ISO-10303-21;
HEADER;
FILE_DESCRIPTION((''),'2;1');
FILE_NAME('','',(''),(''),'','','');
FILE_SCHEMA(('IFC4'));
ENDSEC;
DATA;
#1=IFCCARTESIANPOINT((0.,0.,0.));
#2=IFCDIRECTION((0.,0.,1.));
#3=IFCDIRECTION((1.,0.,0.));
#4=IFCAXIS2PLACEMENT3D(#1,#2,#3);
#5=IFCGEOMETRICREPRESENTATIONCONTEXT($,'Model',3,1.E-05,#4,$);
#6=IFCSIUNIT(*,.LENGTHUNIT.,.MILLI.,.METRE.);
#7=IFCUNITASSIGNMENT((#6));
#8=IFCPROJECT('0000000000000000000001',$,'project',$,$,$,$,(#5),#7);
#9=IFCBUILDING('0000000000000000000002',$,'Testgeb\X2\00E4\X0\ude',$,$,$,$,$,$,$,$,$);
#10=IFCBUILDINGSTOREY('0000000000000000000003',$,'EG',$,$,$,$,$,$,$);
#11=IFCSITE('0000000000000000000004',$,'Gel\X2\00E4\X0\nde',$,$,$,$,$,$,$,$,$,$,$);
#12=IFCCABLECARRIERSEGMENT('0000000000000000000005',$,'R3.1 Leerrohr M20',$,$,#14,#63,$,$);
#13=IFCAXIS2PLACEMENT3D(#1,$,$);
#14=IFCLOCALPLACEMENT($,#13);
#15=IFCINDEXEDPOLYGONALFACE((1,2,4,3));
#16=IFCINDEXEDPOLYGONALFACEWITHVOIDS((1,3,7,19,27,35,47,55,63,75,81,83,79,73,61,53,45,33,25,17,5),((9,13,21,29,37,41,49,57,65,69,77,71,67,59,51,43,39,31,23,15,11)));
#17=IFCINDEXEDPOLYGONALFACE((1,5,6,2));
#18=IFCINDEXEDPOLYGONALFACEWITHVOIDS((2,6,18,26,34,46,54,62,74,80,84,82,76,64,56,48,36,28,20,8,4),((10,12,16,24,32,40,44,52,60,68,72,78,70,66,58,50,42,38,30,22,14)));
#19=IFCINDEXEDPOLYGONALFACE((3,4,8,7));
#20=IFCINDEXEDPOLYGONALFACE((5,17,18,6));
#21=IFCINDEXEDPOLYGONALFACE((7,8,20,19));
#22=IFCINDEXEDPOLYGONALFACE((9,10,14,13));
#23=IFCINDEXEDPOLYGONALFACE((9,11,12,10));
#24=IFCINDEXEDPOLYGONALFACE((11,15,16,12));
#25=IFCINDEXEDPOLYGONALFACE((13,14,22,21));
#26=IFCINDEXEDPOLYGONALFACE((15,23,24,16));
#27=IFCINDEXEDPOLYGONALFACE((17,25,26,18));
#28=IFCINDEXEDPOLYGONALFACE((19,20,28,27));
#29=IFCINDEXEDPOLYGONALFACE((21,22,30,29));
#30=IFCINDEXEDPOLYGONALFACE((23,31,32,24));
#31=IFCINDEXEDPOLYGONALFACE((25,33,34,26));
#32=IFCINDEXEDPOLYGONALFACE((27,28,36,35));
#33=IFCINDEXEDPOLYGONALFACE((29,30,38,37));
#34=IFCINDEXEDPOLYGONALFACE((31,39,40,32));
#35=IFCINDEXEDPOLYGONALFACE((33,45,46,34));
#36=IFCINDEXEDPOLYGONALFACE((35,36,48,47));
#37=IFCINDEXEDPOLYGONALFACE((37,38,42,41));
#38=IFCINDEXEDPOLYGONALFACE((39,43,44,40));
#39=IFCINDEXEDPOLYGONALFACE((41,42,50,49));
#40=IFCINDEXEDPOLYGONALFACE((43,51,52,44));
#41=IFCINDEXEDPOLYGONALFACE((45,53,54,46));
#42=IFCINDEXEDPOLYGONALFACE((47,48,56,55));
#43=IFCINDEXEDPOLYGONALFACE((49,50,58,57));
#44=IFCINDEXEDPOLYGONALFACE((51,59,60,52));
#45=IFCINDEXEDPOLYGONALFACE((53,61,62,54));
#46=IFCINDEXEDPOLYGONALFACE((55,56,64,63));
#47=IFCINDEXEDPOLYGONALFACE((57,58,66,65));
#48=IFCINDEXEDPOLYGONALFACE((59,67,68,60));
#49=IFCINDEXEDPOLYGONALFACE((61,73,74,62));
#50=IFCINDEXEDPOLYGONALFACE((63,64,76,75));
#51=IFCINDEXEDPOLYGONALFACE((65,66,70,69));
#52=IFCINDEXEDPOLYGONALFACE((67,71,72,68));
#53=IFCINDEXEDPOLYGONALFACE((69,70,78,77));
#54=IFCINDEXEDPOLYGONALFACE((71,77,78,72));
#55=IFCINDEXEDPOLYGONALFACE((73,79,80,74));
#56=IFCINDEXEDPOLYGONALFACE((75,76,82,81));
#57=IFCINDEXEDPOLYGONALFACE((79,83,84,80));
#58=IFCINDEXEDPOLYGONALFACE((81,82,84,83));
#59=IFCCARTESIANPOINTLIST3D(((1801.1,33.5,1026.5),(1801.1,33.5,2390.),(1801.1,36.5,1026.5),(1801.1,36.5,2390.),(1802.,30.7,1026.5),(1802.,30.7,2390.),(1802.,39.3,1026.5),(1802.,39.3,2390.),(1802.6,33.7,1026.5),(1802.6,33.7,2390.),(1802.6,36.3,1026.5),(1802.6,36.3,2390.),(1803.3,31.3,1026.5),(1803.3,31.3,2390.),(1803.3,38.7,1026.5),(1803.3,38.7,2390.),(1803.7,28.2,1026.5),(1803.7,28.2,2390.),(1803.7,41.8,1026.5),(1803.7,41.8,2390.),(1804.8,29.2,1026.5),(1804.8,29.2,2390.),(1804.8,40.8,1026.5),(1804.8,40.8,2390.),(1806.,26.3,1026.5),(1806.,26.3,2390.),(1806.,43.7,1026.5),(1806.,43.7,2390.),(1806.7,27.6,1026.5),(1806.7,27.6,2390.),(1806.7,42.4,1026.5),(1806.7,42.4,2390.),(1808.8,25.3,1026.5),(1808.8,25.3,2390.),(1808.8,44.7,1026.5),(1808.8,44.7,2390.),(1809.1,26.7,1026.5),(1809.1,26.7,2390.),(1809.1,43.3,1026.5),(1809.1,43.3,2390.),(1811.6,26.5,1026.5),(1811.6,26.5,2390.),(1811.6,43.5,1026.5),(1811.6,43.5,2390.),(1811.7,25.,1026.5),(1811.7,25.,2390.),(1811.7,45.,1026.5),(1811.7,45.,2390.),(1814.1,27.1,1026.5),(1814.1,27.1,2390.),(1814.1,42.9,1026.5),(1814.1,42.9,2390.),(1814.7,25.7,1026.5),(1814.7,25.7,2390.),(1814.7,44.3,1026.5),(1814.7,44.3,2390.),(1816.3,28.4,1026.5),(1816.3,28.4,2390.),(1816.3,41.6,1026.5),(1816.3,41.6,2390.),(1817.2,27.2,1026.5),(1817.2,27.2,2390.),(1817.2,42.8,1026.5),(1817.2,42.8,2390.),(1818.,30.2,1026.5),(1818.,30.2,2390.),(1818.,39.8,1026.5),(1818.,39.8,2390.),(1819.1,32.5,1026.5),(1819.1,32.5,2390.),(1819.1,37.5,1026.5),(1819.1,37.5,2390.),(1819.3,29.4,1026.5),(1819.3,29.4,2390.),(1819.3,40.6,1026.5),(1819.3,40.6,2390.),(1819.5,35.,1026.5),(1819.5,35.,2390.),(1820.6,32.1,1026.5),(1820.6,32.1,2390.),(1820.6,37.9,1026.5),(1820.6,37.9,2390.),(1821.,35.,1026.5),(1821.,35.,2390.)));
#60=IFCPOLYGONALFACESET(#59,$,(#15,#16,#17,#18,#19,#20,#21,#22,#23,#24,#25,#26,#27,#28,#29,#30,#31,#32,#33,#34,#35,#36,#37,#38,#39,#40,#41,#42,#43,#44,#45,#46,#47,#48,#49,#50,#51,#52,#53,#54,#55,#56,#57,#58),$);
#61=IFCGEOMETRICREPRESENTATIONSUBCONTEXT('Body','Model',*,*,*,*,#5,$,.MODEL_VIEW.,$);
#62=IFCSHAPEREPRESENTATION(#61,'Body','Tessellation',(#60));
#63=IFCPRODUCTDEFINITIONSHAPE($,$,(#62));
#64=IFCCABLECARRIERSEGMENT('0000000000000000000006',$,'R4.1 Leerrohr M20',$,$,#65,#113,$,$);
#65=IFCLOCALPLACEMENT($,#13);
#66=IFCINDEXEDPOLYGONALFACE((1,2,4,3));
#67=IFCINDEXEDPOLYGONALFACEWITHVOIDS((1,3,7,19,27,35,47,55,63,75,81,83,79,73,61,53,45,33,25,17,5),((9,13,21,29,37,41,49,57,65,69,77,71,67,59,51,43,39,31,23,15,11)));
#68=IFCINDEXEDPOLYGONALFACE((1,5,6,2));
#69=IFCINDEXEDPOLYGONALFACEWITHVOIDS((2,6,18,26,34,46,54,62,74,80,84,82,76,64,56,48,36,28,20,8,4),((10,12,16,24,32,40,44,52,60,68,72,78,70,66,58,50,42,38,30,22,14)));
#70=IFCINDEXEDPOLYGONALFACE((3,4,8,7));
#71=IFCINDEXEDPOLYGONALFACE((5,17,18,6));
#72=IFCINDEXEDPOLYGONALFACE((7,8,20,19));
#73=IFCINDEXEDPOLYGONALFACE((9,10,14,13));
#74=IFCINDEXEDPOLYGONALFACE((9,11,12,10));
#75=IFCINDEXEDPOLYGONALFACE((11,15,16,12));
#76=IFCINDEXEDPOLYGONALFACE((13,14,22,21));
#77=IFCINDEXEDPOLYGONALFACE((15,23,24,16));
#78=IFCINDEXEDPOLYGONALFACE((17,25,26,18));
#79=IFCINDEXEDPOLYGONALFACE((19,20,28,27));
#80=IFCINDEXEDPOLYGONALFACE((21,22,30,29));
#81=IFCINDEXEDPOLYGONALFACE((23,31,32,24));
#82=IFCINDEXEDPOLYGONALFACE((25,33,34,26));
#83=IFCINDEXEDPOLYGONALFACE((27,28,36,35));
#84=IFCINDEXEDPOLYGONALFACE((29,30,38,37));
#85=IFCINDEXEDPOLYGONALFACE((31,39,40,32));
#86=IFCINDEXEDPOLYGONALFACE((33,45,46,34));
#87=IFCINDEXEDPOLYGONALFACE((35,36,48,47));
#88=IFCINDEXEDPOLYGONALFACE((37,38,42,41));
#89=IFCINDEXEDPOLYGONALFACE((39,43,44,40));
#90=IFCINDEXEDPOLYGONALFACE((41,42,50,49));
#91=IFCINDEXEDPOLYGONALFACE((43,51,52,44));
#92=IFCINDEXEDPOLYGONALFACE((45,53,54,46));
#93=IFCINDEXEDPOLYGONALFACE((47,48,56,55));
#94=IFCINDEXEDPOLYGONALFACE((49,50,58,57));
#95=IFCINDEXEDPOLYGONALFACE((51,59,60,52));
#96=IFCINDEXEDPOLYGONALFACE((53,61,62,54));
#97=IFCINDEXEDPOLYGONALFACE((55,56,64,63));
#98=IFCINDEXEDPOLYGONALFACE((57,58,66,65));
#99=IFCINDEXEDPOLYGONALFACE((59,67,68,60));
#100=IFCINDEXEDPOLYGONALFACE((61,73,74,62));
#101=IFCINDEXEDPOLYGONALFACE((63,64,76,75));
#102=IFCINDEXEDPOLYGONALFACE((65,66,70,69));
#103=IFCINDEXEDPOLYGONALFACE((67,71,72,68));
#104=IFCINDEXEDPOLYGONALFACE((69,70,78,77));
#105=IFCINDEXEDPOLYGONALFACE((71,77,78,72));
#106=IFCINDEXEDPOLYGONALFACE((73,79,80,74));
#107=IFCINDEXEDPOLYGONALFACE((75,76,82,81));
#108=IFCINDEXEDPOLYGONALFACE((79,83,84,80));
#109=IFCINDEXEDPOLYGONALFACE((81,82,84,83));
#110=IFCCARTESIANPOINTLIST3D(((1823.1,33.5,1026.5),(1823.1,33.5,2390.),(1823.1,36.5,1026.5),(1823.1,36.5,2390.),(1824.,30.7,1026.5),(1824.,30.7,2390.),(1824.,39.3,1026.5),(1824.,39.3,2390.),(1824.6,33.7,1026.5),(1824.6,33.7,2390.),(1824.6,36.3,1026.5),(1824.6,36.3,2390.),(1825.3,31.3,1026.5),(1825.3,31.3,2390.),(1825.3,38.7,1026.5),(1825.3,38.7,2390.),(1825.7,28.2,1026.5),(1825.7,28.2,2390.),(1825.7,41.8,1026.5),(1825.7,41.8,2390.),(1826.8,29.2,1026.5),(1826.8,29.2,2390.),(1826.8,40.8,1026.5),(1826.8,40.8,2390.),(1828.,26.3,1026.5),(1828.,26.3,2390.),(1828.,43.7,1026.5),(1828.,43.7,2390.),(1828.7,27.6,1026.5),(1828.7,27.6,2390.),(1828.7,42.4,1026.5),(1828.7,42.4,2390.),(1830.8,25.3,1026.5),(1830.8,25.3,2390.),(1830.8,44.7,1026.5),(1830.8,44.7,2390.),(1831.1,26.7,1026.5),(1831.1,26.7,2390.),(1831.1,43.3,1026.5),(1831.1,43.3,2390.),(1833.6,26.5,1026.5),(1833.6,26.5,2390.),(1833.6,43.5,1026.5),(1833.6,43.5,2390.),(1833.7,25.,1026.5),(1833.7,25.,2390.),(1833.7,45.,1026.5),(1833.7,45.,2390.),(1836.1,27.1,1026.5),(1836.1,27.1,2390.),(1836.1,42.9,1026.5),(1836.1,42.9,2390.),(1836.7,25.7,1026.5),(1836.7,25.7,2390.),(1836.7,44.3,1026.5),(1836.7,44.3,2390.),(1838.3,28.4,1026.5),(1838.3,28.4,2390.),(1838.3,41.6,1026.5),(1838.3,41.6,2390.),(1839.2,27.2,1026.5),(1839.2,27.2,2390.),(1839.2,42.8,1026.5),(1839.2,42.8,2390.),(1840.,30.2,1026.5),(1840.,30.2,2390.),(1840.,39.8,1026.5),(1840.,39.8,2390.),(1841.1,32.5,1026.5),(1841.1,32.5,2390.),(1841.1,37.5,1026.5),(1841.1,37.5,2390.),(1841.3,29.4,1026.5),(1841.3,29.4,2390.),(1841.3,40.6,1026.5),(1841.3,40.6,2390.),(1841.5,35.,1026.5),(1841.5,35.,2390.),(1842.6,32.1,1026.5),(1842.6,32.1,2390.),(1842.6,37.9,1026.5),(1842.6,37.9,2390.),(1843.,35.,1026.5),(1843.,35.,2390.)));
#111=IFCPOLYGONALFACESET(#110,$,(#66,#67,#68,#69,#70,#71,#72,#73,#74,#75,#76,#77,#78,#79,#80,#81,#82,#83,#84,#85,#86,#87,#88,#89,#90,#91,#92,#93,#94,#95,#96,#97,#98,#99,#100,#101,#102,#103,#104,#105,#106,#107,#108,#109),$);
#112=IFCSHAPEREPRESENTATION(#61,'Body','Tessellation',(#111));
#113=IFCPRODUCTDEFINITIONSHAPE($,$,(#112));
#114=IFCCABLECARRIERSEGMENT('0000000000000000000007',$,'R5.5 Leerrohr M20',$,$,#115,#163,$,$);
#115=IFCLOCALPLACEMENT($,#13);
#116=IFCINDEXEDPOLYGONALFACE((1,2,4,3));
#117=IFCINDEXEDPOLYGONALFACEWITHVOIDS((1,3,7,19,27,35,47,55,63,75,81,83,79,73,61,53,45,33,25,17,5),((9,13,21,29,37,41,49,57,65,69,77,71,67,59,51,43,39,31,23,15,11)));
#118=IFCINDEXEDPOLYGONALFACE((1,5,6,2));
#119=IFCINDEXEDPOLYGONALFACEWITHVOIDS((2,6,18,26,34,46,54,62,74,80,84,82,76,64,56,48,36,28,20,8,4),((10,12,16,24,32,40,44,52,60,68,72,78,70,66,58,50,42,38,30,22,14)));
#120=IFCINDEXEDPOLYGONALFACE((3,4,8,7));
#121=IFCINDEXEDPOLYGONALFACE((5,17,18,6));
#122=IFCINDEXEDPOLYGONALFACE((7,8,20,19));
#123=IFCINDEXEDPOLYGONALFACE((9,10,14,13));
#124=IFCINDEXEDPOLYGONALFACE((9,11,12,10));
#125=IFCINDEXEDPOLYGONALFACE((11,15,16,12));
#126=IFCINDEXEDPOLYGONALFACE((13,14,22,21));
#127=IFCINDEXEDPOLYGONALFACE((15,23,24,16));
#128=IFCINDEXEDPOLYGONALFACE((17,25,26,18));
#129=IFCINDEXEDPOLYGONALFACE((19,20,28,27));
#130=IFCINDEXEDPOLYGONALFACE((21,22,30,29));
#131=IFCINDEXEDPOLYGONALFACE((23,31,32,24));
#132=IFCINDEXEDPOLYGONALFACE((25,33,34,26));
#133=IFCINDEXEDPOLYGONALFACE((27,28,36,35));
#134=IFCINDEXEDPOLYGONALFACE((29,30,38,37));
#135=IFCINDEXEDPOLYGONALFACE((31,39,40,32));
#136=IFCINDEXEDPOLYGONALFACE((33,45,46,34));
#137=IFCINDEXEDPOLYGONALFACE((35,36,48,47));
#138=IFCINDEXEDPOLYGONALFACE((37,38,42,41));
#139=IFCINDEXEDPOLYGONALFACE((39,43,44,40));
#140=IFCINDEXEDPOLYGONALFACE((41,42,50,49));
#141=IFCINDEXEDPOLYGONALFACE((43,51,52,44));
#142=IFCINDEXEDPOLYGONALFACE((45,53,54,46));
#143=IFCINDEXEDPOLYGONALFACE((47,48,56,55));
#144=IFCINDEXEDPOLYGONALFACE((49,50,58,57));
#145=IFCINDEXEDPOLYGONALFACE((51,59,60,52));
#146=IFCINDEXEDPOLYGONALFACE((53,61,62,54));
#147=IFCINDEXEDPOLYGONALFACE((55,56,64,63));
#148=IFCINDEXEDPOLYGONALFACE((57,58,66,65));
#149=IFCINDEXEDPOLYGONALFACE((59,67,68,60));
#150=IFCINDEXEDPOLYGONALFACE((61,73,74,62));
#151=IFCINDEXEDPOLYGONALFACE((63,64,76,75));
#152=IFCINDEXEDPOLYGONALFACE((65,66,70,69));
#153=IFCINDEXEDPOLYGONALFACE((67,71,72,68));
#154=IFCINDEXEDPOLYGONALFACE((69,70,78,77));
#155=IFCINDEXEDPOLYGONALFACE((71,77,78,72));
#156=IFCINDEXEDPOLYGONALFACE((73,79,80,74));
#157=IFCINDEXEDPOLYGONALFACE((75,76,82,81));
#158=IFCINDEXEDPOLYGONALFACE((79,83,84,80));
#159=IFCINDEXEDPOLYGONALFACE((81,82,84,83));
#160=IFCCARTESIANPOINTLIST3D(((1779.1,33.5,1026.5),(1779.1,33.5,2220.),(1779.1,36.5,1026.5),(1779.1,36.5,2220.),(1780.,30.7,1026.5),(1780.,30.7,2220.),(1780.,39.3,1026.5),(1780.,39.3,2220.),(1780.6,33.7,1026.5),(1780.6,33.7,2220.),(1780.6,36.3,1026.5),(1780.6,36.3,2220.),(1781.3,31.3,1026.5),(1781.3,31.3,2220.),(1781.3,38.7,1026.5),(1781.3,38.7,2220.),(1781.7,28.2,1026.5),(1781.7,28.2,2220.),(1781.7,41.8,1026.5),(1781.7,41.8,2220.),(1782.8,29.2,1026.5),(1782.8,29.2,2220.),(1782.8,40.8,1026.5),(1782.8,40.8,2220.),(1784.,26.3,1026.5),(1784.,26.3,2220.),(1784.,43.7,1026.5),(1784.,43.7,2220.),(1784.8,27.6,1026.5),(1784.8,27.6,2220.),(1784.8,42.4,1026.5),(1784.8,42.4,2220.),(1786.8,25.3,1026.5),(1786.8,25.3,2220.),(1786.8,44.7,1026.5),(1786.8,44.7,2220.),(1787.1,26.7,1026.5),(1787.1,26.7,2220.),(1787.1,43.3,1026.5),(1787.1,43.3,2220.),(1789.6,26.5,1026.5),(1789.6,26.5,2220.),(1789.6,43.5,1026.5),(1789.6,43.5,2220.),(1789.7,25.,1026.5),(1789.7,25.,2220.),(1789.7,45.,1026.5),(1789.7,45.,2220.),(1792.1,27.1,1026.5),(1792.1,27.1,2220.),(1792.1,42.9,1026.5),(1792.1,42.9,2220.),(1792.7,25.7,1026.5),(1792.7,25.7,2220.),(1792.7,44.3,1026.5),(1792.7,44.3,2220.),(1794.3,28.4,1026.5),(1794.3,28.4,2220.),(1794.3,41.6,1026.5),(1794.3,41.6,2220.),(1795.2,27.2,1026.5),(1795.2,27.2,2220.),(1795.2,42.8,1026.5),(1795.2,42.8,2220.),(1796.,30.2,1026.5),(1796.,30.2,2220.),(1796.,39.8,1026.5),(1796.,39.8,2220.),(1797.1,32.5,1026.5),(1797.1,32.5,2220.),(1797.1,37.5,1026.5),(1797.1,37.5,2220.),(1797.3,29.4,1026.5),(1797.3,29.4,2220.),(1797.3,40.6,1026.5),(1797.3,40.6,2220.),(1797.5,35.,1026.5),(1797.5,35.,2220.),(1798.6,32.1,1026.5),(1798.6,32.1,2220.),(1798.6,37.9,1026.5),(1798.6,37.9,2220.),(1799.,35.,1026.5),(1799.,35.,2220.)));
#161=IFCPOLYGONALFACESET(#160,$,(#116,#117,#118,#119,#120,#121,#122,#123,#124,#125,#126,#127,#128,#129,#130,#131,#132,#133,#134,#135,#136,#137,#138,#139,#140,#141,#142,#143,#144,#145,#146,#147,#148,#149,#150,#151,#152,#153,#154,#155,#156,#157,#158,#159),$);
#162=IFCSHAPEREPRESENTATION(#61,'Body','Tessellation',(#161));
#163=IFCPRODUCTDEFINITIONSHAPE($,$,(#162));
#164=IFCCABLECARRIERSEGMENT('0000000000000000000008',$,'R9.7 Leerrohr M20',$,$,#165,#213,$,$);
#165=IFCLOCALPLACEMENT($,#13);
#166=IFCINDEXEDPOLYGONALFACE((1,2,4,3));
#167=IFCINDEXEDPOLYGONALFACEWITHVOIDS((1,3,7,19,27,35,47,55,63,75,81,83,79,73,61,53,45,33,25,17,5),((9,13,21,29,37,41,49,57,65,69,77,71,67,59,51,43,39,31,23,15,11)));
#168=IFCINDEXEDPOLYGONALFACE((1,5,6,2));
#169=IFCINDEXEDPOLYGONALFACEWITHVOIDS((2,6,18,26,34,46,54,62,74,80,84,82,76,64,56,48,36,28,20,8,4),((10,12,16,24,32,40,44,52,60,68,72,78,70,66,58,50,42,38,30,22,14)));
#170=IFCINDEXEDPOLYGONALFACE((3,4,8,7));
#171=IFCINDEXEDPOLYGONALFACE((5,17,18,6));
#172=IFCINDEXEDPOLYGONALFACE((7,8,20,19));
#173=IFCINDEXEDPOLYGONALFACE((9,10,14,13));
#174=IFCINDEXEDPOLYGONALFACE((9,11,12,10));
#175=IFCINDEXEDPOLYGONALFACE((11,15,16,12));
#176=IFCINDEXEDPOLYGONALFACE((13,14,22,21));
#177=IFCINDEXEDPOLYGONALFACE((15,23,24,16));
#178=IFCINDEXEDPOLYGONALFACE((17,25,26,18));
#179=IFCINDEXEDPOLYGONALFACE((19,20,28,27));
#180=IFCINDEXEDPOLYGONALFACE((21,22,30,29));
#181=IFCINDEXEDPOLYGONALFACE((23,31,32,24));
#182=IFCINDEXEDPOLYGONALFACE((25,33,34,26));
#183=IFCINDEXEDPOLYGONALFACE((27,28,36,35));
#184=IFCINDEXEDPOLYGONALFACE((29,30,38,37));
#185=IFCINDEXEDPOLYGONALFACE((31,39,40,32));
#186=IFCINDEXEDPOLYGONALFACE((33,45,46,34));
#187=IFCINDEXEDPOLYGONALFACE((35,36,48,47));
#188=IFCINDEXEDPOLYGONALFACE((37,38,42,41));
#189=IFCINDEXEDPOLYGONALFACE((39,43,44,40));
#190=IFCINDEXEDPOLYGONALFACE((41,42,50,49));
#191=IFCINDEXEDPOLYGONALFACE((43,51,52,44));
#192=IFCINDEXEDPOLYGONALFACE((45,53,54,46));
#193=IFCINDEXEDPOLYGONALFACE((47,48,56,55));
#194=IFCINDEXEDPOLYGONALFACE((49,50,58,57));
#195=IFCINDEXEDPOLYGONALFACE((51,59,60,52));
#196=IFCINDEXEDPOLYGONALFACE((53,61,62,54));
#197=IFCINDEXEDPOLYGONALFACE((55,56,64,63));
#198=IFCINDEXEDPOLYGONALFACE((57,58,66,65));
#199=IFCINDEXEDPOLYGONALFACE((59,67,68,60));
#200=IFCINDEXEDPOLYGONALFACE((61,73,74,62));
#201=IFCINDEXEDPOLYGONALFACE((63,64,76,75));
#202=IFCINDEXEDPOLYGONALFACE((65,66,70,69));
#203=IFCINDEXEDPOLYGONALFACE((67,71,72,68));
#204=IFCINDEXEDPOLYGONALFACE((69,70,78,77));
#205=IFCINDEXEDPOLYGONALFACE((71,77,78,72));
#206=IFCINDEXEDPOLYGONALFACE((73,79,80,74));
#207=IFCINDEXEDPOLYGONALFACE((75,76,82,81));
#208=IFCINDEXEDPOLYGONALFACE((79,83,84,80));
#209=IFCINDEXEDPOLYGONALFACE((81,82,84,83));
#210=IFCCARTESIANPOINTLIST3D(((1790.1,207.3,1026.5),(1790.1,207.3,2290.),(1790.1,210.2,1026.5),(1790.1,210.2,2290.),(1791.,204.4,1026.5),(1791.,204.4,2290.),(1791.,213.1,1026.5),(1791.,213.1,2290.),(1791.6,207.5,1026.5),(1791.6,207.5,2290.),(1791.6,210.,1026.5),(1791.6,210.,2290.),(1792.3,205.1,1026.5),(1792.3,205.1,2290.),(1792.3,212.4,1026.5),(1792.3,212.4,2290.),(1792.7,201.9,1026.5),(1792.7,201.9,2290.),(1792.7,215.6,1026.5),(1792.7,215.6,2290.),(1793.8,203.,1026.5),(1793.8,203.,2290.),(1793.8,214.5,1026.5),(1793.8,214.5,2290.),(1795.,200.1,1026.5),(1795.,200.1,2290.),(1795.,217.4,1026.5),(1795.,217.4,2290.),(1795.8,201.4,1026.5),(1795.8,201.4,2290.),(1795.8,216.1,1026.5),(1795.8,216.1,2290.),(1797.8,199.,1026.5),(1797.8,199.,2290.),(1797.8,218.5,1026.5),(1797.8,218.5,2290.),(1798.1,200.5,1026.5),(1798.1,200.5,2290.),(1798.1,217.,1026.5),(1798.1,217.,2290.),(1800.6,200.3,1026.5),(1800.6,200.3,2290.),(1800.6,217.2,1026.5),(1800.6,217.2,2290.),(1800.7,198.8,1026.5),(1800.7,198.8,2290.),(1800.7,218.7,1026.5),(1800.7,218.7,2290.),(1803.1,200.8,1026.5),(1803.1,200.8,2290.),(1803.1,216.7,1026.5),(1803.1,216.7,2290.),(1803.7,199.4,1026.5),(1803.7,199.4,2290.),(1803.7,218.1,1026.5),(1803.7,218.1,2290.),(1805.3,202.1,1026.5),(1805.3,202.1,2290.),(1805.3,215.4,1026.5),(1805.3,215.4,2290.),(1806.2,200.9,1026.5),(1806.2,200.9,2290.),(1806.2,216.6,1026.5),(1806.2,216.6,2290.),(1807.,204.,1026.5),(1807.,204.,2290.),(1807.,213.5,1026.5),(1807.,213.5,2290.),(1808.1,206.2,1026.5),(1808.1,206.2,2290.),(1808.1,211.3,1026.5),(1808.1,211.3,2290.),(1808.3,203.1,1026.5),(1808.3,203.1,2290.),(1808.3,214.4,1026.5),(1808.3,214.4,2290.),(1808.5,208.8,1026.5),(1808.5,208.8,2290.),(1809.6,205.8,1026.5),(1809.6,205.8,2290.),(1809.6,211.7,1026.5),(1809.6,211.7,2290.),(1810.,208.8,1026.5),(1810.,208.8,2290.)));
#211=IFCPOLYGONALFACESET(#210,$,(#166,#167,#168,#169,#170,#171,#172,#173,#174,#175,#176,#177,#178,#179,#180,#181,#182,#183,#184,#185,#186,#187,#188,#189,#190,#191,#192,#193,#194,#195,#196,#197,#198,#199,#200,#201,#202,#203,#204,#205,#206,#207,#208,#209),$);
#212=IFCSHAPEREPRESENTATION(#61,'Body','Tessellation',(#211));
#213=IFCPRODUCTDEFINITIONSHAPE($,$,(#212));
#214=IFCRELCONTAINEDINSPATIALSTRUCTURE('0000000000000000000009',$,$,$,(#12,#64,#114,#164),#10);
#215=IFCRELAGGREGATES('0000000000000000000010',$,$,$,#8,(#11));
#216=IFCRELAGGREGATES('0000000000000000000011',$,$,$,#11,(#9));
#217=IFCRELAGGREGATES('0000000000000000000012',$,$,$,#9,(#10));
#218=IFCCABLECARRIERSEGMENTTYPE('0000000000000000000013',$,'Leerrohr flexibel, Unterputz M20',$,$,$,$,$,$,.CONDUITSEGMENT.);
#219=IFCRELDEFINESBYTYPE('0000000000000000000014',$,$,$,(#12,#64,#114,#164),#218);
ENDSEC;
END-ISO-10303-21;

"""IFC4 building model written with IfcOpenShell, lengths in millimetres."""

from ifc_helpers import new_model, si_unit, frame, origin_with_axes, place, context, subcontext, project, spatial, hollow_circle, extrude, type_object, element, save


model = new_model("IFC4")

# Units and contexts
model_context = context("Model", 3, precision=1e-05, world=origin_with_axes())
body_context = subcontext(model_context, "Body", "Model", "MODEL_VIEW")
ifc_project = project(units=[si_unit("LENGTHUNIT", "METRE", prefix="MILLI")], contexts=[model_context])

# Site, building, storey
site = spatial("IfcSite", under=ifc_project, Name="Gelände")
building = spatial("IfcBuilding", under=site, Name="Testgebäude")
storey = spatial("IfcBuildingStorey", under=building, Name="EG")

# Cable carrier segments
cable_carrier_segment_type_1 = type_object("IfcCableCarrierSegmentType", Name="Leerrohr flexibel, Unterputz M20", PredefinedType="CONDUITSEGMENT")
for number, where, z_axis, x_axis, name in (
    (1, (1811.0, 35.0, 1026.5), (0.0, 0.0, 1.0), (1.0, 0.0, 0.0), "R3.1 Leerrohr M20"),
    (2, (1833.0, 35.0, 1026.5), (0.0, 0.0, 1.0), (1.0, 0.0, 0.0), "R4.1 Leerrohr M20"),
):
    element("IfcCableCarrierSegment", number, at=place(None, frame(where, z_axis=z_axis, x_axis=x_axis)), inside=storey, type_object=cable_carrier_segment_type_1, Name=name, context=body_context, shape_type="SweptSolid", body=[
        extrude(hollow_circle(Radius=10.0, WallThickness=1.5), None, (0.0, 0.0, 1.0), 1363.5),
    ])
cable_carrier_segment_1_placement = place(None, frame((1789.0, 35.0, 2220.0), z_axis=(0.0, 0.0, -1.0), x_axis=(1.0, 0.0, 0.0)))
element("IfcCableCarrierSegment", 3, at=cable_carrier_segment_1_placement, inside=storey, type_object=cable_carrier_segment_type_1, Name="R5.5 Leerrohr M20", context=body_context, shape_type="SweptSolid", body=[
    extrude(hollow_circle(Radius=10.0, WallThickness=1.5), None, (0.0, 0.0, 1.0), 1193.5),
])
cable_carrier_segment_2_placement = place(None, frame((1800.0, 208.8, 2290.0), z_axis=(0.0, 0.0, -1.0), x_axis=(1.0, 0.0, 0.0)))
element("IfcCableCarrierSegment", 4, at=cable_carrier_segment_2_placement, inside=storey, type_object=cable_carrier_segment_type_1, Name="R9.7 Leerrohr M20", context=body_context, shape_type="SweptSolid", body=[
    extrude(hollow_circle(Radius=10.0, WallThickness=1.5), None, (0.0, 0.0, 1.0), 1263.5),
])

save(model, "model.ifc")
